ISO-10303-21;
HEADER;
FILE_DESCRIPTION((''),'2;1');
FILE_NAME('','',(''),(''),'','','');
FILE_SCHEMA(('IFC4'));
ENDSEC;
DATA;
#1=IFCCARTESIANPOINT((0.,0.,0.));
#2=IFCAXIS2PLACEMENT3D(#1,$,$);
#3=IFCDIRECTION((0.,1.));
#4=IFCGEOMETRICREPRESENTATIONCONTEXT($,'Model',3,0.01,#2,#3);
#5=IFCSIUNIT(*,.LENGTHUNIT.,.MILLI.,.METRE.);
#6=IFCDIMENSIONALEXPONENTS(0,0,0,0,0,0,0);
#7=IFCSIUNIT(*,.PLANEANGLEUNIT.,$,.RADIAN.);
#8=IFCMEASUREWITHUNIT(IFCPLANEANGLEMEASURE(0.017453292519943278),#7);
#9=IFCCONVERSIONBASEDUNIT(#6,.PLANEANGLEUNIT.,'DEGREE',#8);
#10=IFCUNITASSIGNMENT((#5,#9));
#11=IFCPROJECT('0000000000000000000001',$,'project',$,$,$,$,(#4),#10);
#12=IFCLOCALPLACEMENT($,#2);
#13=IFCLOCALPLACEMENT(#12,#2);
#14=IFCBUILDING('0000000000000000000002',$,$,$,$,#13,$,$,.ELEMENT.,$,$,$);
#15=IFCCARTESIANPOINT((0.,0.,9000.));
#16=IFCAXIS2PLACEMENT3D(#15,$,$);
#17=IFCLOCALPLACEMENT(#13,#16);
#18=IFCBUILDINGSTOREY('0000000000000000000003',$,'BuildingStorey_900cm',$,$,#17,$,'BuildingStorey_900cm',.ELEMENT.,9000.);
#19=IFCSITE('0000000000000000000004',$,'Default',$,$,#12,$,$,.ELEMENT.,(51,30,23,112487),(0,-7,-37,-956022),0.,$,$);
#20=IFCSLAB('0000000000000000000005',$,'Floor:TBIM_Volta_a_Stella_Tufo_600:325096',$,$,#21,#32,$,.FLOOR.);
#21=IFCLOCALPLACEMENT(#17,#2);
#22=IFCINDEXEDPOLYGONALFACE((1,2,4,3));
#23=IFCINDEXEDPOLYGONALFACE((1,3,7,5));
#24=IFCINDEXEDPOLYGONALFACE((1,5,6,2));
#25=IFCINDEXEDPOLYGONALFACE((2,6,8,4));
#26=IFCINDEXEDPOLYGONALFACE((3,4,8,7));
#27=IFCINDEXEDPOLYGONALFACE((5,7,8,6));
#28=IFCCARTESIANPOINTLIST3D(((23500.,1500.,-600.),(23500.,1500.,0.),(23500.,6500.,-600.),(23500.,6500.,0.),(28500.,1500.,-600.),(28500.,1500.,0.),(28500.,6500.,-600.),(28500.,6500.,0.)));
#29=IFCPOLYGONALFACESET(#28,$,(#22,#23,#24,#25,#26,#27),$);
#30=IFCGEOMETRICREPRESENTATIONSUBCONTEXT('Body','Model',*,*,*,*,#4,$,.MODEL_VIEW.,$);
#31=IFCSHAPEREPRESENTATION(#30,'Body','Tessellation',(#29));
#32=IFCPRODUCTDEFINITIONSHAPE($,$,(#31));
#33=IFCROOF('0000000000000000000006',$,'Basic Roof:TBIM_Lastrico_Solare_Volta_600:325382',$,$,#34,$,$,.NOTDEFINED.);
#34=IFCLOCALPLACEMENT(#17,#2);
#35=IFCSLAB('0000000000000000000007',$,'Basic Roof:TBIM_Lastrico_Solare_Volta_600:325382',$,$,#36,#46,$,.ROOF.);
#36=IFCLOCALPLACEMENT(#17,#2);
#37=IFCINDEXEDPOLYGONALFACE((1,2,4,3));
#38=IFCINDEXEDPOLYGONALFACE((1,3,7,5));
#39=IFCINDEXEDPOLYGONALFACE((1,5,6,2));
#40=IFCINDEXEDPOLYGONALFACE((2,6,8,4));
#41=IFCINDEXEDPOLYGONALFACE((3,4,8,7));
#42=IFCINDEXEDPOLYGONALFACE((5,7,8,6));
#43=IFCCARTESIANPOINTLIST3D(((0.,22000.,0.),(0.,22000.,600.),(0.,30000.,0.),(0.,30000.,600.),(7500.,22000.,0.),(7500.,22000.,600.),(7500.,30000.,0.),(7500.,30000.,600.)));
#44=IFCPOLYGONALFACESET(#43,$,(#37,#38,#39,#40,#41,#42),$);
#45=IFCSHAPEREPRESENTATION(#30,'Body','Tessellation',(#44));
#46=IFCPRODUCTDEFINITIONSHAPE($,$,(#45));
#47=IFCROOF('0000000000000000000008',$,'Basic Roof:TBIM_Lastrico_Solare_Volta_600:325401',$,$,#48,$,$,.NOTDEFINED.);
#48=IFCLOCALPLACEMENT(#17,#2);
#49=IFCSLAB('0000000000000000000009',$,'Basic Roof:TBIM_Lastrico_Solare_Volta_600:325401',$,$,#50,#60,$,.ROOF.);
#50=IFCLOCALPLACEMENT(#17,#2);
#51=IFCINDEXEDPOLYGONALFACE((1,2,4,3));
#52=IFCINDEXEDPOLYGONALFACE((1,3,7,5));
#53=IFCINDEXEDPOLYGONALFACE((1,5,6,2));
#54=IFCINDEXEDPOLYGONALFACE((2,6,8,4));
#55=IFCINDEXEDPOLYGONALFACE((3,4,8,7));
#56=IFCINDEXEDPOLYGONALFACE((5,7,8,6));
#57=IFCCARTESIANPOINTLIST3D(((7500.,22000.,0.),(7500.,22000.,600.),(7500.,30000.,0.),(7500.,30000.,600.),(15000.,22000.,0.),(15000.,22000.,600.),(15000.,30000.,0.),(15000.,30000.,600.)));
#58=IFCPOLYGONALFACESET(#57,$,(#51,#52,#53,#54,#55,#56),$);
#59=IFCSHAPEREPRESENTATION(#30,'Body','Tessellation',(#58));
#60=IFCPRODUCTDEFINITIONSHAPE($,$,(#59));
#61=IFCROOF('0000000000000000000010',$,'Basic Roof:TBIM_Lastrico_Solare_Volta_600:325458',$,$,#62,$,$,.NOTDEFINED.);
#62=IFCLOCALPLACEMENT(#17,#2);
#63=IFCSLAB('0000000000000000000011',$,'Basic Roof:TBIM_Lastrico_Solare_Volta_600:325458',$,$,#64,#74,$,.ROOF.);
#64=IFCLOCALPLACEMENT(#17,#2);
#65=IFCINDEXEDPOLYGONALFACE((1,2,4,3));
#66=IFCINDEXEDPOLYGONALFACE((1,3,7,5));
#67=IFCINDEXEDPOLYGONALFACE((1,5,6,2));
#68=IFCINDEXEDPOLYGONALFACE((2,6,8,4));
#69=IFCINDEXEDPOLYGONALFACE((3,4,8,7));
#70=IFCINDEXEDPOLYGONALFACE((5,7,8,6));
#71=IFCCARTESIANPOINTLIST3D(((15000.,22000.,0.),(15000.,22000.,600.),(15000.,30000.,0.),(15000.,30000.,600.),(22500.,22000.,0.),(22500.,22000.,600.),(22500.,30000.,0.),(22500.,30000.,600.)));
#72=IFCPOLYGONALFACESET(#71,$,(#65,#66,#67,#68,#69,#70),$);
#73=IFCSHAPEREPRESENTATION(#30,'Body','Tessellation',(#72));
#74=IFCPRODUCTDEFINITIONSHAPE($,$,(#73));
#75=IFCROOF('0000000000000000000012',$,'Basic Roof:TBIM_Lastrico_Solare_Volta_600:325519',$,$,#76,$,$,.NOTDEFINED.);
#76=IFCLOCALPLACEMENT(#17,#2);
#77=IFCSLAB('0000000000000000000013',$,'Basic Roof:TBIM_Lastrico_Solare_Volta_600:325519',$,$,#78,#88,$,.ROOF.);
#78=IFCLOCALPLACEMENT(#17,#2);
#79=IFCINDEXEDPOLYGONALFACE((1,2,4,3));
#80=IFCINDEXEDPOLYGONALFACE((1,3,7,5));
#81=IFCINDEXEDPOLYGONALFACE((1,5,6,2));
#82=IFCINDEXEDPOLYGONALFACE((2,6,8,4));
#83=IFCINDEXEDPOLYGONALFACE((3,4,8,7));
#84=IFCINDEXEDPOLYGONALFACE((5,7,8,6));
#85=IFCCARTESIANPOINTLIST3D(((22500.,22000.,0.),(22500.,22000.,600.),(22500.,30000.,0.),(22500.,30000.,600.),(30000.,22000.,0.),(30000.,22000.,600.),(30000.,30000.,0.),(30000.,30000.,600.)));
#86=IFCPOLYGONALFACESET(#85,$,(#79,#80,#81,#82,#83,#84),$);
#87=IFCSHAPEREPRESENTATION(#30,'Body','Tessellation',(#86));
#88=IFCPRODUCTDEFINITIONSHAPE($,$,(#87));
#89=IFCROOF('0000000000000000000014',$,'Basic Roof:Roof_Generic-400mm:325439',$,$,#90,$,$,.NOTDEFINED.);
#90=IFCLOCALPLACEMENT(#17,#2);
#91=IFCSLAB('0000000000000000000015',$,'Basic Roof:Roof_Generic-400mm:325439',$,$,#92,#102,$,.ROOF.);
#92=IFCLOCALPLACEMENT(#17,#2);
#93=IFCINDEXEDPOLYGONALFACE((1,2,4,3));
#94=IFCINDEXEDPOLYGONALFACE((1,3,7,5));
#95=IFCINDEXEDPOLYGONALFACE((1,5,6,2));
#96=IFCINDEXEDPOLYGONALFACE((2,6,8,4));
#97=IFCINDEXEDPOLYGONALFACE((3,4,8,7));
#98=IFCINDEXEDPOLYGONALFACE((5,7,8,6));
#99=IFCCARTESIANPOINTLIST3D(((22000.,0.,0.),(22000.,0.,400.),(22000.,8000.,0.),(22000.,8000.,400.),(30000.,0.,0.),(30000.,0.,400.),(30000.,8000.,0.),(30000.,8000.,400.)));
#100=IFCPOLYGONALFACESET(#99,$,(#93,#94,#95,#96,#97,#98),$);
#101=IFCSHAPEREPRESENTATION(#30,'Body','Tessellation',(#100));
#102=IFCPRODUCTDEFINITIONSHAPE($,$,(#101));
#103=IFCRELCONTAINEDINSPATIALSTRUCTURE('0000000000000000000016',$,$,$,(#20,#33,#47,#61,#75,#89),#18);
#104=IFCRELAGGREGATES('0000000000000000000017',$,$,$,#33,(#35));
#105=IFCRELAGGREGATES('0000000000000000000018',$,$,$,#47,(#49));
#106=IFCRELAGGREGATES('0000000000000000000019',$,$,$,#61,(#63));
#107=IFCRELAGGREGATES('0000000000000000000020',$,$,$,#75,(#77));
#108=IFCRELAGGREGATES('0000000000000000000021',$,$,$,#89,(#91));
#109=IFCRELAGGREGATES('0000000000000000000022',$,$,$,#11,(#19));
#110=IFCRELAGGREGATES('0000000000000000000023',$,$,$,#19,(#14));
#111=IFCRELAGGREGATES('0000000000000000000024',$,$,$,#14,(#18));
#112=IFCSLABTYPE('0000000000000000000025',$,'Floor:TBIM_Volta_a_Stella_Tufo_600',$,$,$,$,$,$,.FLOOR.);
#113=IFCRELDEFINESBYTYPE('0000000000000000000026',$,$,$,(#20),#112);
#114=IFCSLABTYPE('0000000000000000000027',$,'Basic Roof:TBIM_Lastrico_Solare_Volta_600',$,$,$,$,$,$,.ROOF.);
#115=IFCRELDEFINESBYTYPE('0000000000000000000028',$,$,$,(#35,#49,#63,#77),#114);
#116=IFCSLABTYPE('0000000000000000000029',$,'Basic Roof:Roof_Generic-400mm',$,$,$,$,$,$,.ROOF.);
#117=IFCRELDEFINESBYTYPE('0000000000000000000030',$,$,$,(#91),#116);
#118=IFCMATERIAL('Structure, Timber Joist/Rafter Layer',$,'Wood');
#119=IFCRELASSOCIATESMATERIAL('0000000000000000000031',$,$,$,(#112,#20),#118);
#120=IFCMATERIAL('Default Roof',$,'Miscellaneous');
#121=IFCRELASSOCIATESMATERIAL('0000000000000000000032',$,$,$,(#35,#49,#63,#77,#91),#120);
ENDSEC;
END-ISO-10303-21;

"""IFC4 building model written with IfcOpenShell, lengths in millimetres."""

from ifc_helpers import new_model, entity, si_unit, converted_unit, direction, frame, origin, place, context, subcontext, project, spatial, indexed_curve, outline, extrude, material, type_object, element, aggregate, save


model = new_model("IFC4")

# Units and contexts
model_context = context("Model", 3, precision=0.01, world=origin(), true_north=direction((0.0, 1.0)))
body_context = subcontext(model_context, "Body", "Model", "MODEL_VIEW")
ifc_project = project(units=[si_unit("LENGTHUNIT", "METRE", prefix="MILLI"), converted_unit("PLANEANGLEUNIT", "DEGREE", entity("IfcPlaneAngleMeasure", 0.017453292519943278), si_unit("PLANEANGLEUNIT", "RADIAN"), dimensions=[0, 0, 0, 0, 0, 0, 0])], contexts=[model_context])

# Site, building, storey
site_placement = place(None, origin())
site = spatial("IfcSite", under=ifc_project, at=site_placement, Name="Default", CompositionType="ELEMENT", RefLatitude=(51, 30, 23, 112487), RefLongitude=(0, -7, -37, -956022), RefElevation=0.0)
building_placement = place(site_placement, origin())
building = spatial("IfcBuilding", under=site, at=building_placement, CompositionType="ELEMENT")
storey_placement = place(building_placement, frame((0.0, 0.0, 9000.0)))
storey = spatial("IfcBuildingStorey", under=building, at=storey_placement, Name="BuildingStorey_900cm", LongName="BuildingStorey_900cm", CompositionType="ELEMENT", Elevation=9000.0)

# Slab
ifc_material_1 = material(Name="Structure, Timber Joist/Rafter Layer", Category="Wood")
slab_type_1 = type_object("IfcSlabType", Name="Floor:TBIM_Volta_a_Stella_Tufo_600", PredefinedType="FLOOR", material=ifc_material_1)
slab_1_placement = place(storey_placement, origin())
element("IfcSlab", 1, at=slab_1_placement, inside=storey, type_object=slab_type_1, material=ifc_material_1, Name="Floor:TBIM_Volta_a_Stella_Tufo_600:325096", PredefinedType="FLOOR", context=body_context, shape_type="SweptSolid", body=[
    extrude(outline(indexed_curve([(-2500.0, -2500.0), (2500.0, -2500.0), (2500.0, 2500.0), (-2500.0, 2500.0), (-2500.0, -2500.0)], self_intersect=False)), frame((26000.0, 4000.0, 0.0), z_axis=(0.0, 0.0, -1.0), x_axis=(0.0, 1.0, 0.0)), (0.0, 0.0, 1.0), 600.0),
])

# Roofs, slabs
roof_1_placement = place(storey_placement, frame((0.0, 22000.0, 0.0)))
roof_1 = element("IfcRoof", 2, at=roof_1_placement, inside=storey, Name="Basic Roof:TBIM_Lastrico_Solare_Volta_600:325382", PredefinedType="NOTDEFINED")
ifc_material_2 = material(Name="Default Roof", Category="Miscellaneous")
slab_type_2 = type_object("IfcSlabType", Name="Basic Roof:TBIM_Lastrico_Solare_Volta_600", PredefinedType="ROOF")
slab_2_placement = place(roof_1_placement, origin())
slab_2 = element("IfcSlab", 3, at=slab_2_placement, type_object=slab_type_2, material=ifc_material_2, Name="Basic Roof:TBIM_Lastrico_Solare_Volta_600:325382", PredefinedType="ROOF", context=body_context, shape_type="SweptSolid", body=[
    extrude(outline(indexed_curve([(-3750.0, 4000.0), (-3750.0, -4000.0), (3750.0, -4000.0), (3750.0, 4000.0), (-3750.0, 4000.0)], self_intersect=False)), frame((3750.0, 4000.0, 0.0)), (0.0, 0.0, 1.0), 600.0),
])
aggregate(roof_1, [slab_2])
roof_2_placement = place(storey_placement, frame((7500.0, 22000.0, 0.0)))
roof_2 = element("IfcRoof", 4, at=roof_2_placement, inside=storey, Name="Basic Roof:TBIM_Lastrico_Solare_Volta_600:325401", PredefinedType="NOTDEFINED")
slab_3_placement = place(roof_2_placement, origin())
slab_3 = element("IfcSlab", 5, at=slab_3_placement, type_object=slab_type_2, material=ifc_material_2, Name="Basic Roof:TBIM_Lastrico_Solare_Volta_600:325401", PredefinedType="ROOF", context=body_context, shape_type="SweptSolid", body=[
    extrude(outline(indexed_curve([(-3750.0, 4000.0), (-3750.0, -4000.0), (3750.0, -4000.0), (3750.0, 4000.0), (-3750.0, 4000.0)], self_intersect=False)), frame((3750.0, 4000.0, 0.0)), (0.0, 0.0, 1.0), 600.0),
])
aggregate(roof_2, [slab_3])
roof_3_placement = place(storey_placement, frame((15000.0, 22000.0, 0.0)))
roof_3 = element("IfcRoof", 6, at=roof_3_placement, inside=storey, Name="Basic Roof:TBIM_Lastrico_Solare_Volta_600:325458", PredefinedType="NOTDEFINED")
slab_4_placement = place(roof_3_placement, origin())
slab_4 = element("IfcSlab", 7, at=slab_4_placement, type_object=slab_type_2, material=ifc_material_2, Name="Basic Roof:TBIM_Lastrico_Solare_Volta_600:325458", PredefinedType="ROOF", context=body_context, shape_type="SweptSolid", body=[
    extrude(outline(indexed_curve([(-3750.0, 4000.0), (-3750.0, -4000.0), (3750.0, -4000.0), (3750.0, 4000.0), (-3750.0, 4000.0)], self_intersect=False)), frame((3750.0, 4000.0, 0.0)), (0.0, 0.0, 1.0), 600.0),
])
aggregate(roof_3, [slab_4])
roof_4_placement = place(storey_placement, frame((22500.0, 22000.0, 0.0)))
roof_4 = element("IfcRoof", 8, at=roof_4_placement, inside=storey, Name="Basic Roof:TBIM_Lastrico_Solare_Volta_600:325519", PredefinedType="NOTDEFINED")
slab_5_placement = place(roof_4_placement, origin())
slab_5 = element("IfcSlab", 9, at=slab_5_placement, type_object=slab_type_2, material=ifc_material_2, Name="Basic Roof:TBIM_Lastrico_Solare_Volta_600:325519", PredefinedType="ROOF", context=body_context, shape_type="SweptSolid", body=[
    extrude(outline(indexed_curve([(-3750.0, 4000.0), (-3750.0, -4000.0), (3750.0, -4000.0), (3750.0, 4000.0), (-3750.0, 4000.0)], self_intersect=False)), frame((3750.0, 4000.0, 0.0)), (0.0, 0.0, 1.0), 600.0),
])
aggregate(roof_4, [slab_5])
roof_5_placement = place(storey_placement, frame((22000.0, 0.0, 0.0)))
roof_5 = element("IfcRoof", 10, at=roof_5_placement, inside=storey, Name="Basic Roof:Roof_Generic-400mm:325439", PredefinedType="NOTDEFINED")
slab_type_3 = type_object("IfcSlabType", Name="Basic Roof:Roof_Generic-400mm", PredefinedType="ROOF")
slab_6_placement = place(roof_5_placement, origin())
slab_6 = element("IfcSlab", 11, at=slab_6_placement, type_object=slab_type_3, material=ifc_material_2, Name="Basic Roof:Roof_Generic-400mm:325439", PredefinedType="ROOF", context=body_context, shape_type="SweptSolid", body=[
    extrude(outline(indexed_curve([(-4000.0, 4000.0), (-4000.0, -4000.0), (4000.0, -4000.0), (4000.0, 4000.0), (-4000.0, 4000.0)], self_intersect=False)), frame((4000.0, 4000.0, 0.0)), (0.0, 0.0, 1.0), 400.0),
])
aggregate(roof_5, [slab_6])

save(model, "model.ifc")
